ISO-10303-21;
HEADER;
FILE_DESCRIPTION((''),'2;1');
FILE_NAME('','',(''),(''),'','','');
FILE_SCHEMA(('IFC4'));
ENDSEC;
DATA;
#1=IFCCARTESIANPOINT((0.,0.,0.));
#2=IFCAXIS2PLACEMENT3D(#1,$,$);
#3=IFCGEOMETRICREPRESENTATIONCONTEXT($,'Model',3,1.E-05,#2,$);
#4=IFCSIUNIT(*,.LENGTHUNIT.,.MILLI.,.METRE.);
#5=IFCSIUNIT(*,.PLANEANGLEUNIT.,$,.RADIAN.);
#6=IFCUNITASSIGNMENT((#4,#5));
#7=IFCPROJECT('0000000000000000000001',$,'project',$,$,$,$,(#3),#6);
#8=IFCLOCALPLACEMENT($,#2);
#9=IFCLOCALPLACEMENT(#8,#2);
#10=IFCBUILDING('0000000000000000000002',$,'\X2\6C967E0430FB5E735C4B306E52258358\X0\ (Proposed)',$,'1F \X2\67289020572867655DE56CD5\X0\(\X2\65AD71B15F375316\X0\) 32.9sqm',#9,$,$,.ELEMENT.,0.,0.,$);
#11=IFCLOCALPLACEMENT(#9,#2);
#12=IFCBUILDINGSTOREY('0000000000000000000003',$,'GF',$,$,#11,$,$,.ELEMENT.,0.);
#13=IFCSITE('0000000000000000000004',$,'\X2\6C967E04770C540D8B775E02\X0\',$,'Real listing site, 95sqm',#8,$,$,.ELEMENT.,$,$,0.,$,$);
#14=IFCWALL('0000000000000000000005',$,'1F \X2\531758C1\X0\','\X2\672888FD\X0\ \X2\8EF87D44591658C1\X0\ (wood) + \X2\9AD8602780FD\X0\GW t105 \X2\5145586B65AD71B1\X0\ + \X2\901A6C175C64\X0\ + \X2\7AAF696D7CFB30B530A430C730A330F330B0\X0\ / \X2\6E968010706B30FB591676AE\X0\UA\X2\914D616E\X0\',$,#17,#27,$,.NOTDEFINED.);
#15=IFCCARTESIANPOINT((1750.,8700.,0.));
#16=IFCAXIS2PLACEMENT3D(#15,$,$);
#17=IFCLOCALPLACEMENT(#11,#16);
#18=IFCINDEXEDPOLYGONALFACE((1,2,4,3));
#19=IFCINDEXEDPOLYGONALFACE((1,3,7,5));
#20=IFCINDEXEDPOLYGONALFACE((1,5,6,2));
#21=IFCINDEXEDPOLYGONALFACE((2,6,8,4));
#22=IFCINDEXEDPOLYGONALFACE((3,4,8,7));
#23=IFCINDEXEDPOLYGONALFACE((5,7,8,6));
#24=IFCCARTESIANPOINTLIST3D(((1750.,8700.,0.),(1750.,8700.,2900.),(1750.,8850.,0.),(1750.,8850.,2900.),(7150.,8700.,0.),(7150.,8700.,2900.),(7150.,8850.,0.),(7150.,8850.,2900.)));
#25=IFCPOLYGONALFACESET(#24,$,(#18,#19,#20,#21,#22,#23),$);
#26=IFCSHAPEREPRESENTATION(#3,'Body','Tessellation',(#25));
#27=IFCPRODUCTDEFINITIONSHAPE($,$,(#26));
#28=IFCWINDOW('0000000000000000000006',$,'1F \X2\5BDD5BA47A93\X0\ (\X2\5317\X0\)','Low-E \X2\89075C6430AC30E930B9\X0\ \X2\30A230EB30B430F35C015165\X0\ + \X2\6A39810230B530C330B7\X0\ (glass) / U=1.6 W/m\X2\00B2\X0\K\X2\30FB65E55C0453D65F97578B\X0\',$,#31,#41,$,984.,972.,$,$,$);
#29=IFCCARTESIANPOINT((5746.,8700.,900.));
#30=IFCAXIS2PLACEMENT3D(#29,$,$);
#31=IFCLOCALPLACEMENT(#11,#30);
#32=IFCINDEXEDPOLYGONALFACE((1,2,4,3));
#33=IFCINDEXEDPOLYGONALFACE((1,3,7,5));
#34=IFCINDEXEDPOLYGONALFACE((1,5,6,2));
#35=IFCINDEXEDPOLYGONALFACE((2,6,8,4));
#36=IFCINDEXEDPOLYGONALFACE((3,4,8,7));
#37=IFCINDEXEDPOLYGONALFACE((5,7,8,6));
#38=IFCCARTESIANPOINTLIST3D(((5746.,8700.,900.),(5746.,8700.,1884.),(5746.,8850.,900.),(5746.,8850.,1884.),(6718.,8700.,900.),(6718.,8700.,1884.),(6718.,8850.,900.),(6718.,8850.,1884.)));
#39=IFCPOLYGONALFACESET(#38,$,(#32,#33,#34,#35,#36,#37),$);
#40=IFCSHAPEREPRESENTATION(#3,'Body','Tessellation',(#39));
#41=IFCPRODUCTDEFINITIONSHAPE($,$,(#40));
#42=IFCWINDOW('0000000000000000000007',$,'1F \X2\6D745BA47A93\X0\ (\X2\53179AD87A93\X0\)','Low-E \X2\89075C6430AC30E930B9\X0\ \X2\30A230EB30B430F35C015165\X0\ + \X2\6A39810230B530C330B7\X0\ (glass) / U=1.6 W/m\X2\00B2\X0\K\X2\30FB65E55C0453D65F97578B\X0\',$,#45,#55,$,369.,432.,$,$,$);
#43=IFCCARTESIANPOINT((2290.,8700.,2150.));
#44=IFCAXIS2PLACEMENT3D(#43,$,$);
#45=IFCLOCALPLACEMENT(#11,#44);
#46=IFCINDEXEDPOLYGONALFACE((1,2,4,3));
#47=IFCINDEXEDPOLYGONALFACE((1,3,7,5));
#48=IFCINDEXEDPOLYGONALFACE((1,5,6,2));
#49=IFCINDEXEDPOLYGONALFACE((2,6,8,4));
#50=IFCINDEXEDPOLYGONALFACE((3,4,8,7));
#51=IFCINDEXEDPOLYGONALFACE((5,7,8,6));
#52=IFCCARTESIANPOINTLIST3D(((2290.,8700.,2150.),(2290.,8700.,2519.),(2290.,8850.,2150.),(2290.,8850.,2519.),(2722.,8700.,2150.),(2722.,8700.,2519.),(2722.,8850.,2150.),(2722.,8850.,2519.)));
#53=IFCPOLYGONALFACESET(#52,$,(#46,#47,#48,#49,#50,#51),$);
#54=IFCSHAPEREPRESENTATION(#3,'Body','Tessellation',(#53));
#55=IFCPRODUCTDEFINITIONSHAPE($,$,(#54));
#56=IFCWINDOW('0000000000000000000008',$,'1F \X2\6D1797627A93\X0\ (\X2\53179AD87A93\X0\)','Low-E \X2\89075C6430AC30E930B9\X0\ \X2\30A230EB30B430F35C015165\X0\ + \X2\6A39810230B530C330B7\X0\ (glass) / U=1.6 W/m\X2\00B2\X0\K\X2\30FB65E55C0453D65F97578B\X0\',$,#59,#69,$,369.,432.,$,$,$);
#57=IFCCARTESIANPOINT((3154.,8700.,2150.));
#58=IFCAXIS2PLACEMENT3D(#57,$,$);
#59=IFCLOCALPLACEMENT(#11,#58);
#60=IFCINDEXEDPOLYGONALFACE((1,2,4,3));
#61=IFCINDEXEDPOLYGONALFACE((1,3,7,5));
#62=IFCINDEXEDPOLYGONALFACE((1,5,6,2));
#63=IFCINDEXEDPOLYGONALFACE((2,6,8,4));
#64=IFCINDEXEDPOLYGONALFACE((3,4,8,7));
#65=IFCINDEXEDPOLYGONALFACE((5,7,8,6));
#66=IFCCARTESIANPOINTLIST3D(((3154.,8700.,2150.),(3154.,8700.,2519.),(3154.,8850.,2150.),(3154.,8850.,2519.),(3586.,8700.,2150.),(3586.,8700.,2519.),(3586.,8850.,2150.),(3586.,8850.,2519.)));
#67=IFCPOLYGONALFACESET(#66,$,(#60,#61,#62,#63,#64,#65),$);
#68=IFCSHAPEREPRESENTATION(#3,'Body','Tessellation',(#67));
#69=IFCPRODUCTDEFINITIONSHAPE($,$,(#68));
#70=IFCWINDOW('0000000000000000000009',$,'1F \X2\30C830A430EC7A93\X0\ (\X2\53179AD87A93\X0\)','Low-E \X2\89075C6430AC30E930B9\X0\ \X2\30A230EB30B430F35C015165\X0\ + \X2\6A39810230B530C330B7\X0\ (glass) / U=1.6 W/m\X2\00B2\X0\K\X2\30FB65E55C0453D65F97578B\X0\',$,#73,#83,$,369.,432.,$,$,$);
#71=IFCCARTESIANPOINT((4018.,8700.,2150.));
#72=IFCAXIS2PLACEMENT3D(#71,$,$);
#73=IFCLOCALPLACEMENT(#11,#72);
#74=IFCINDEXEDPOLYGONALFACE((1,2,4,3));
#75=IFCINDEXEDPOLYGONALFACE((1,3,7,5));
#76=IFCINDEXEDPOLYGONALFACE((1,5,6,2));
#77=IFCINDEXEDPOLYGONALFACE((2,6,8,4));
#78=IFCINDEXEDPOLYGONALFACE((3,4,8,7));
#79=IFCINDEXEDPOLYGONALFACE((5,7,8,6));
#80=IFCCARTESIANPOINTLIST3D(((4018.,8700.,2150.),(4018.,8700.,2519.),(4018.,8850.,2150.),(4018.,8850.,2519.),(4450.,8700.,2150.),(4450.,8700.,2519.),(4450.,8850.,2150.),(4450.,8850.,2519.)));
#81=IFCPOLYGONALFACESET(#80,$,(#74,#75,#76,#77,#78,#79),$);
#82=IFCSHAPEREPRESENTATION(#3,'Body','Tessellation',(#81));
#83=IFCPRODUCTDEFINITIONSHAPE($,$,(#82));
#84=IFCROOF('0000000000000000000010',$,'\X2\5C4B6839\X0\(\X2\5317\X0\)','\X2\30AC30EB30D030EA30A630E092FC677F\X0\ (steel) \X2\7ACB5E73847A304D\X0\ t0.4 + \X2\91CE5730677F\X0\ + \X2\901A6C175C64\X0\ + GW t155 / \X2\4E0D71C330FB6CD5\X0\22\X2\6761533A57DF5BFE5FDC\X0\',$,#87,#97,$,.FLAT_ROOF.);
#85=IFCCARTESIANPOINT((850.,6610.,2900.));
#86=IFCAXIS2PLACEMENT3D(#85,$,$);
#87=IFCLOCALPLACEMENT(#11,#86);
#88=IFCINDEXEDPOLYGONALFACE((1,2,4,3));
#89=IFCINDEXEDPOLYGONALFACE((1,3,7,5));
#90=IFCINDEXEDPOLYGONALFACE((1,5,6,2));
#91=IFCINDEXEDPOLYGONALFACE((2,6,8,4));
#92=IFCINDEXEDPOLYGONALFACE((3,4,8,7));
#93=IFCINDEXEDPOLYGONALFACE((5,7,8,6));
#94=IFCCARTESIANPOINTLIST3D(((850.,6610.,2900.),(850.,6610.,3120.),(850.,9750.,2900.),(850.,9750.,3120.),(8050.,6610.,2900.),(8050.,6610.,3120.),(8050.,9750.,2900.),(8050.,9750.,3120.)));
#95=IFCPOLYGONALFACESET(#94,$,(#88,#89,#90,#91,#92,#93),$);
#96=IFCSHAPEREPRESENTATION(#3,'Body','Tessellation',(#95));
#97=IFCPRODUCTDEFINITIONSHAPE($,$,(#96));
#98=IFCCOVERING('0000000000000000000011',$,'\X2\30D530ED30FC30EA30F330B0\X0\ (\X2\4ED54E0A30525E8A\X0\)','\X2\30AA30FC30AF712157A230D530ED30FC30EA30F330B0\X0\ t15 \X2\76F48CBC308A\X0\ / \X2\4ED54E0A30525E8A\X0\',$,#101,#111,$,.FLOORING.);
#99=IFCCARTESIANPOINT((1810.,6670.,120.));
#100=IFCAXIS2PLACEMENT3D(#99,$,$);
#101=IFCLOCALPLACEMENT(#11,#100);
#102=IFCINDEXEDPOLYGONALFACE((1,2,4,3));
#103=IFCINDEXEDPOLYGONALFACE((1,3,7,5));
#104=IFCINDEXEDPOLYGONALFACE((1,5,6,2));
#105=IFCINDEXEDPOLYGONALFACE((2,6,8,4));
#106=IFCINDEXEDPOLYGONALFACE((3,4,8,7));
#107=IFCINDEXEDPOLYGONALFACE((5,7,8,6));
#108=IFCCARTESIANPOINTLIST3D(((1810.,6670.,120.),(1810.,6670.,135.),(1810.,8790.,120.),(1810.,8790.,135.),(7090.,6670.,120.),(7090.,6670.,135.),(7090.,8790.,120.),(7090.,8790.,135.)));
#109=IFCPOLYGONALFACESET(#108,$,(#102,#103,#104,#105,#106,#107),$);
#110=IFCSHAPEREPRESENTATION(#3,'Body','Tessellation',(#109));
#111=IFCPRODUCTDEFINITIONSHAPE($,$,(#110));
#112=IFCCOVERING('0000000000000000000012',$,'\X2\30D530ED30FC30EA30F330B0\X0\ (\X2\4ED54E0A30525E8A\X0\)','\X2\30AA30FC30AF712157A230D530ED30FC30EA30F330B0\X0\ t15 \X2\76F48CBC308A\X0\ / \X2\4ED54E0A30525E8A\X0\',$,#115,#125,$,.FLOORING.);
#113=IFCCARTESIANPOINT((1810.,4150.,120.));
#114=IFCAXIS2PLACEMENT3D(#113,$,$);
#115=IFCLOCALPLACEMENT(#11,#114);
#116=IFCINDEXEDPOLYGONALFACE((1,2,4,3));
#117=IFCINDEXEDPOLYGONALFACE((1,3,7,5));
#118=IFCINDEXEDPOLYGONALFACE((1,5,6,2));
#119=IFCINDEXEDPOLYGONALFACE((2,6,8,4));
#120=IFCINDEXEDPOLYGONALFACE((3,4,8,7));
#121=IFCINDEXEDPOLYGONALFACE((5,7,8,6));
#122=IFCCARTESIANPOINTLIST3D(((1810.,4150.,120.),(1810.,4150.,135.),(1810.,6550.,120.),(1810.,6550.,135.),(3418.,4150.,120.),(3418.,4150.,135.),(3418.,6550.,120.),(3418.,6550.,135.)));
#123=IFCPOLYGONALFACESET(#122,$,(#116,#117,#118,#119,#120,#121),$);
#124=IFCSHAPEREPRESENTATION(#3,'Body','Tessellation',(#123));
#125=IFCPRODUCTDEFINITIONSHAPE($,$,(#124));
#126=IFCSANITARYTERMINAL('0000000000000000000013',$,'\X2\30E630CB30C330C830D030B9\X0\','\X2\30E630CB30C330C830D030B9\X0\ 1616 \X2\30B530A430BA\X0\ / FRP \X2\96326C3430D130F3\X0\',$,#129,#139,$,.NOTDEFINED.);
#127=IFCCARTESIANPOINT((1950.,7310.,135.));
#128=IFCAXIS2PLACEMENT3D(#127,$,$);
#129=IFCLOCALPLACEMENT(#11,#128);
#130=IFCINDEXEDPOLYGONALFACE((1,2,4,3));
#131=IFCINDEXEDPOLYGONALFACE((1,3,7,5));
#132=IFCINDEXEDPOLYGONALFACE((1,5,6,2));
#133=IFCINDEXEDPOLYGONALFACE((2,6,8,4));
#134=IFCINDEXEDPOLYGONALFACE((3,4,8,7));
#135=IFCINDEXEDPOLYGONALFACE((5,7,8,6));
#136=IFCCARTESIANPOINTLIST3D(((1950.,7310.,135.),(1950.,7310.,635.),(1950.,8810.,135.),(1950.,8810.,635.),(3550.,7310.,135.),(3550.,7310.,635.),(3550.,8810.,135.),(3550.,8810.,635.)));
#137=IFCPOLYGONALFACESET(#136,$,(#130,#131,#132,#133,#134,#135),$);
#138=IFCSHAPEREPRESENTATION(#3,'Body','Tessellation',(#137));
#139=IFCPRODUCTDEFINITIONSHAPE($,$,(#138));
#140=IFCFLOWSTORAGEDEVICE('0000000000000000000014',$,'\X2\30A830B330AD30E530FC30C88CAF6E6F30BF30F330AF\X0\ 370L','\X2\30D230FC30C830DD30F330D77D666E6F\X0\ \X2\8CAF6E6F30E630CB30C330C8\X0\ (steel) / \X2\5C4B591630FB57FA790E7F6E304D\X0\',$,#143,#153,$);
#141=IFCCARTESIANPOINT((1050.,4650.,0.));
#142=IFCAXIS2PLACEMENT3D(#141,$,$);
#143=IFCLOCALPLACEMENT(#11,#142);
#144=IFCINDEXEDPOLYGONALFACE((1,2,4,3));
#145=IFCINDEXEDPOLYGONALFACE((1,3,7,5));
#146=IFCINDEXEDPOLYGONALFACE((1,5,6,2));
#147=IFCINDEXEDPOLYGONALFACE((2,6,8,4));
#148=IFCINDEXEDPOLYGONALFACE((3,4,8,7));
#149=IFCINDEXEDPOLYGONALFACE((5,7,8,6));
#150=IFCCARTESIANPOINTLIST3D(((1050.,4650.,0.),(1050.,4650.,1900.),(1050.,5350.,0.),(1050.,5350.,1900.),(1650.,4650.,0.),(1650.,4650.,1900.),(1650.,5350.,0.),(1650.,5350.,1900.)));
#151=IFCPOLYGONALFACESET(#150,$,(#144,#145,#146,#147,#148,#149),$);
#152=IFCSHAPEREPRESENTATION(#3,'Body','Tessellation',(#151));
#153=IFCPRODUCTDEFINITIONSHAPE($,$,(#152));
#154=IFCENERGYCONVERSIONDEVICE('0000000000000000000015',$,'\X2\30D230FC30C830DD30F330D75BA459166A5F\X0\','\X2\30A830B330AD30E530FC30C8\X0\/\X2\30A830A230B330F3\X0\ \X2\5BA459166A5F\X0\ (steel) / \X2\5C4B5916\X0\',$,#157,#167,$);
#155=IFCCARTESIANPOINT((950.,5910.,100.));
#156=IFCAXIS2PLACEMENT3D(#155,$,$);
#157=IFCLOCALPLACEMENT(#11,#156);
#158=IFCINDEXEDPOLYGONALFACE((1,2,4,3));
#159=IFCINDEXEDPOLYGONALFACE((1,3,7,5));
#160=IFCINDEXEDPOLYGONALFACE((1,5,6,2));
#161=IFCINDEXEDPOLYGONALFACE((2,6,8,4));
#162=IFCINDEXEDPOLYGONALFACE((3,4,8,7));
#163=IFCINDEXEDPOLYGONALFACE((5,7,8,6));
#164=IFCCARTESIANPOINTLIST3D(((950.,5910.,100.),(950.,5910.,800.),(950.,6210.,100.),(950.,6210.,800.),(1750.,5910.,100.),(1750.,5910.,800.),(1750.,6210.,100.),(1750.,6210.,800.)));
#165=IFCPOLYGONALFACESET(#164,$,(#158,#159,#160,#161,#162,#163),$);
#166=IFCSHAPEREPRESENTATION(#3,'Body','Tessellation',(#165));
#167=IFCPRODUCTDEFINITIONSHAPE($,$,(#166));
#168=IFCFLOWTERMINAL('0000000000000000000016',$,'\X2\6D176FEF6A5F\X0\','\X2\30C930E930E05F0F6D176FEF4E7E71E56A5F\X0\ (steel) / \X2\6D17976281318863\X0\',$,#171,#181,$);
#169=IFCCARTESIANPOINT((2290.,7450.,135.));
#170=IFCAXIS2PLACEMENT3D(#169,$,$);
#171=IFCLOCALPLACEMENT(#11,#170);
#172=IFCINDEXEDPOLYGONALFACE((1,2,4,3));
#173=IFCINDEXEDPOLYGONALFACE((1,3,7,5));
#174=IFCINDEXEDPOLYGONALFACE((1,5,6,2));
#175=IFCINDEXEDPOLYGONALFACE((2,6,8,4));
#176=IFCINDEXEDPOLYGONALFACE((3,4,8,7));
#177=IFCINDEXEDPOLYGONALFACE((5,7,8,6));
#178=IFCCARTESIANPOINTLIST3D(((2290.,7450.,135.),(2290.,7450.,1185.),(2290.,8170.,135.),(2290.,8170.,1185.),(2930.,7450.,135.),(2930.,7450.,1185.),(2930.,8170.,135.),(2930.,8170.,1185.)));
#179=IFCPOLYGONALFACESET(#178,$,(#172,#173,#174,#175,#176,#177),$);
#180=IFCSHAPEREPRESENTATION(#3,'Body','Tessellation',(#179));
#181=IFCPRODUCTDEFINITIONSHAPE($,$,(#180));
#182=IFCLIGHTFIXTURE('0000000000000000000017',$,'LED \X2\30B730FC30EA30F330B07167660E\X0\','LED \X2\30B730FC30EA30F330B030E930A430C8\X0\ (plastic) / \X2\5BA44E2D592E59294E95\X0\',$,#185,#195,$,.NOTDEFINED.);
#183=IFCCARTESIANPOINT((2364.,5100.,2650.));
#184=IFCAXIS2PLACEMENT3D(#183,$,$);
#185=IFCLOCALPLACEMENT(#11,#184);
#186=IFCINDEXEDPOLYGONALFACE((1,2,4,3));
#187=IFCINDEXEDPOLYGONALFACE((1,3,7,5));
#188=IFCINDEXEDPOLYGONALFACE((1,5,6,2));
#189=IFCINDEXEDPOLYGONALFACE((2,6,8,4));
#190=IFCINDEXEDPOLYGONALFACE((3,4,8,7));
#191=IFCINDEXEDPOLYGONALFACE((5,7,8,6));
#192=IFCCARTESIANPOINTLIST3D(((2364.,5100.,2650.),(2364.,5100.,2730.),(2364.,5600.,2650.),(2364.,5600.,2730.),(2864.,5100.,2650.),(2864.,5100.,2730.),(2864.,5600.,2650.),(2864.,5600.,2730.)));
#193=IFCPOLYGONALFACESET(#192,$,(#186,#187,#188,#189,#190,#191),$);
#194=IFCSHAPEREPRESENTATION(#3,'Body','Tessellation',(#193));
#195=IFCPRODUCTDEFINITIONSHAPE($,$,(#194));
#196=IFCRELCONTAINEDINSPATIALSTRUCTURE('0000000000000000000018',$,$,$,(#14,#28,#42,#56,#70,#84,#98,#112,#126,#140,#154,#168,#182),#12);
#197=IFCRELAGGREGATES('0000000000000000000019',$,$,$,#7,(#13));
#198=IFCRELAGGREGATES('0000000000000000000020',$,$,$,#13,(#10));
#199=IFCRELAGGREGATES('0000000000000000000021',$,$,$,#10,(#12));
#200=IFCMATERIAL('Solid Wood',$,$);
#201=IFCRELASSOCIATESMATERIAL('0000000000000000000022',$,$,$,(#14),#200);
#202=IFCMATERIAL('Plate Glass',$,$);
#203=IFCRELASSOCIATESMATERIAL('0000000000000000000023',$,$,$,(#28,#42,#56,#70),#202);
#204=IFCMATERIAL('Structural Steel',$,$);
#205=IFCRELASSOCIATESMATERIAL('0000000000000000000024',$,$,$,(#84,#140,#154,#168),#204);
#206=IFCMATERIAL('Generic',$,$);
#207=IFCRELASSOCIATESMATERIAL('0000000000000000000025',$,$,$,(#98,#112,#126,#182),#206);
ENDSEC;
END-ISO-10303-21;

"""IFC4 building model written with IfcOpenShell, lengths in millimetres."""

from ifc_helpers import new_model, si_unit, frame, frame_2d, origin, place, context, project, spatial, rectangle, extrude, material, element, fill, save


model = new_model("IFC4")

# Units and contexts
model_context = context("Model", 3, precision=1e-05, world=origin())
ifc_project = project(units=[si_unit("LENGTHUNIT", "METRE", prefix="MILLI"), si_unit("PLANEANGLEUNIT", "RADIAN")], contexts=[model_context])

# Site, building, storey
site_placement = place(None, origin())
site = spatial("IfcSite", under=ifc_project, at=site_placement, Name="沖縄県名護市", ObjectType="Real listing site, 95sqm", CompositionType="ELEMENT", RefElevation=0.0)
building_placement = place(site_placement, origin())
building = spatial("IfcBuilding", under=site, at=building_placement, Name="沖縄・平屋の別荘 (Proposed)", ObjectType="1F 木造在来工法(断熱強化) 32.9sqm", CompositionType="ELEMENT", ElevationOfRefHeight=0.0, ElevationOfTerrain=0.0)
storey_placement = place(building_placement, origin())
storey = spatial("IfcBuildingStorey", under=building, at=storey_placement, Name="GF", CompositionType="ELEMENT", Elevation=0.0)

# Shared definitions
ifc_material_1 = material(Name="Solid Wood")

# Wall, openings, windows
wall_1_placement = place(storey_placement, frame((1750.0, 8700.0, 0.0)))
wall_1 = element("IfcWall", 1, at=wall_1_placement, inside=storey, material=ifc_material_1, Name="1F 北壁", Description="木製 軸組外壁 (wood) + 高性能GW t105 充填断熱 + 通気層 + 窯業系サイディング / 準耐火・外皮UA配慮", PredefinedType="NOTDEFINED", context=model_context, shape_type="SweptSolid", body=[
    extrude(rectangle(XDim=5400.0, YDim=150.0, at=frame_2d((2700.0, 75.0))), frame((1750.0, 8700.0, 0.0)), (0.0, 0.0, 1.0), 2900.0),
])
opening_1_placement = place(storey_placement, frame((5746.0, 8700.0, 900.0)))
opening_1 = element("IfcOpeningElement", 2, at=opening_1_placement, cuts=wall_1, PredefinedType="NOTDEFINED", context=model_context, shape_type="SweptSolid", body=[
    extrude(rectangle(XDim=972.0, YDim=150.0, at=frame_2d((486.0, 75.0))), frame((5746.0, 8700.0, 900.0)), (0.0, 0.0, 1.0), 984.0),
])
opening_2_placement = place(storey_placement, frame((2290.0, 8700.0, 2150.0)))
opening_2 = element("IfcOpeningElement", 3, at=opening_2_placement, cuts=wall_1, PredefinedType="NOTDEFINED", context=model_context, shape_type="SweptSolid", body=[
    extrude(rectangle(XDim=432.0, YDim=150.0, at=frame_2d((216.0, 75.0))), frame((2290.0, 8700.0, 2150.0)), (0.0, 0.0, 1.0), 369.0),
])
opening_3_placement = place(storey_placement, frame((3154.0, 8700.0, 2150.0)))
opening_3 = element("IfcOpeningElement", 4, at=opening_3_placement, cuts=wall_1, PredefinedType="NOTDEFINED", context=model_context, shape_type="SweptSolid", body=[
    extrude(rectangle(XDim=432.0, YDim=150.0, at=frame_2d((216.0, 75.0))), frame((3154.0, 8700.0, 2150.0)), (0.0, 0.0, 1.0), 369.0),
])
opening_4_placement = place(storey_placement, frame((4018.0, 8700.0, 2150.0)))
opening_4 = element("IfcOpeningElement", 5, at=opening_4_placement, cuts=wall_1, PredefinedType="NOTDEFINED", context=model_context, shape_type="SweptSolid", body=[
    extrude(rectangle(XDim=432.0, YDim=150.0, at=frame_2d((216.0, 75.0))), frame((4018.0, 8700.0, 2150.0)), (0.0, 0.0, 1.0), 369.0),
])
ifc_material_2 = material(Name="Plate Glass")
window_1_placement = place(storey_placement, frame((5746.0, 8700.0, 900.0)))
window_1 = element("IfcWindow", 6, at=window_1_placement, inside=storey, material=ifc_material_2, Name="1F 寝室窓 (北)", Description="Low-E 複層ガラス アルゴン封入 + 樹脂サッシ (glass) / U=1.6 W/m²K・日射取得型", OverallHeight=984.0, OverallWidth=972.0, context=model_context, shape_type="SweptSolid", body=[
    extrude(rectangle(XDim=972.0, YDim=150.0, at=frame_2d((486.0, 75.0))), frame((5746.0, 8700.0, 900.0)), (0.0, 0.0, 1.0), 984.0),
])
fill(opening_1, window_1)
window_2_placement = place(storey_placement, frame((2290.0, 8700.0, 2150.0)))
window_2 = element("IfcWindow", 7, at=window_2_placement, inside=storey, material=ifc_material_2, Name="1F 浴室窓 (北高窓)", Description="Low-E 複層ガラス アルゴン封入 + 樹脂サッシ (glass) / U=1.6 W/m²K・日射取得型", OverallHeight=369.0, OverallWidth=432.0, context=model_context, shape_type="SweptSolid", body=[
    extrude(rectangle(XDim=432.0, YDim=150.0, at=frame_2d((216.0, 75.0))), frame((2290.0, 8700.0, 2150.0)), (0.0, 0.0, 1.0), 369.0),
])
fill(opening_2, window_2)
window_3_placement = place(storey_placement, frame((3154.0, 8700.0, 2150.0)))
window_3 = element("IfcWindow", 8, at=window_3_placement, inside=storey, material=ifc_material_2, Name="1F 洗面窓 (北高窓)", Description="Low-E 複層ガラス アルゴン封入 + 樹脂サッシ (glass) / U=1.6 W/m²K・日射取得型", OverallHeight=369.0, OverallWidth=432.0, context=model_context, shape_type="SweptSolid", body=[
    extrude(rectangle(XDim=432.0, YDim=150.0, at=frame_2d((216.0, 75.0))), frame((3154.0, 8700.0, 2150.0)), (0.0, 0.0, 1.0), 369.0),
])
fill(opening_3, window_3)
window_4_placement = place(storey_placement, frame((4018.0, 8700.0, 2150.0)))
window_4 = element("IfcWindow", 9, at=window_4_placement, inside=storey, material=ifc_material_2, Name="1F トイレ窓 (北高窓)", Description="Low-E 複層ガラス アルゴン封入 + 樹脂サッシ (glass) / U=1.6 W/m²K・日射取得型", OverallHeight=369.0, OverallWidth=432.0, context=model_context, shape_type="SweptSolid", body=[
    extrude(rectangle(XDim=432.0, YDim=150.0, at=frame_2d((216.0, 75.0))), frame((4018.0, 8700.0, 2150.0)), (0.0, 0.0, 1.0), 369.0),
])
fill(opening_4, window_4)

# Roof
ifc_material_3 = material(Name="Structural Steel")
roof_placement = place(storey_placement, frame((850.0, 6610.0, 2900.0)))
element("IfcRoof", 10, at=roof_placement, inside=storey, material=ifc_material_3, Name="屋根(北)", Description="ガルバリウム鋼板 (steel) 立平葺き t0.4 + 野地板 + 通気層 + GW t155 / 不燃・法22条区域対応", PredefinedType="FLAT_ROOF", context=model_context, shape_type="SweptSolid", body=[
    extrude(rectangle(XDim=7200.0, YDim=3140.0, at=frame_2d((3600.0, 1570.0))), frame((850.0, 6610.0, 2900.0)), (0.0, 0.0, 1.0), 220.0),
])

# Coverings
ifc_material_4 = material(Name="Generic")
covering_1_placement = place(storey_placement, frame((1810.0, 6670.0, 120.0)))
element("IfcCovering", 11, at=covering_1_placement, inside=storey, material=ifc_material_4, Name="フローリング (仕上げ床)", Description="オーク無垢フローリング t15 直貼り / 仕上げ床", PredefinedType="FLOORING", context=model_context, shape_type="SweptSolid", body=[
    extrude(rectangle(XDim=5280.0, YDim=2120.0, at=frame_2d((2640.0, 1060.0))), frame((1810.0, 6670.0, 120.0)), (0.0, 0.0, 1.0), 15.0),
])
covering_2_placement = place(storey_placement, frame((1810.0, 4150.0, 120.0)))
element("IfcCovering", 12, at=covering_2_placement, inside=storey, material=ifc_material_4, Name="フローリング (仕上げ床)", Description="オーク無垢フローリング t15 直貼り / 仕上げ床", PredefinedType="FLOORING", context=model_context, shape_type="SweptSolid", body=[
    extrude(rectangle(XDim=1608.0, YDim=2400.0, at=frame_2d((804.0, 1200.0))), frame((1810.0, 4150.0, 120.0)), (0.0, 0.0, 1.0), 15.0),
])

# Sanitary terminal
sanitary_terminal_placement = place(storey_placement, frame((1950.0, 7310.0, 135.0)))
element("IfcSanitaryTerminal", 13, at=sanitary_terminal_placement, inside=storey, material=ifc_material_4, Name="ユニットバス", Description="ユニットバス 1616 サイズ / FRP 防水パン", PredefinedType="NOTDEFINED", context=model_context, shape_type="SweptSolid", body=[
    extrude(rectangle(XDim=1600.0, YDim=1500.0, at=frame_2d((800.0, 750.0))), frame((1950.0, 7310.0, 135.0)), (0.0, 0.0, 1.0), 500.0),
])

# Flow storage device
flow_storage_device_placement = place(storey_placement, frame((1050.0, 4650.0, 0.0)))
element("IfcFlowStorageDevice", 14, at=flow_storage_device_placement, inside=storey, material=ifc_material_3, Name="エコキュート貯湯タンク 370L", Description="ヒートポンプ給湯 貯湯ユニット (steel) / 屋外・基礎置き", context=model_context, shape_type="SweptSolid", body=[
    extrude(rectangle(XDim=600.0, YDim=700.0, at=frame_2d((300.0, 350.0))), frame((1050.0, 4650.0, 0.0)), (0.0, 0.0, 1.0), 1900.0),
])

# Energy conversion device
energy_conversion_device_placement = place(storey_placement, frame((950.0, 5910.0, 100.0)))
element("IfcEnergyConversionDevice", 15, at=energy_conversion_device_placement, inside=storey, material=ifc_material_3, Name="ヒートポンプ室外機", Description="エコキュート/エアコン 室外機 (steel) / 屋外", context=model_context, shape_type="SweptSolid", body=[
    extrude(rectangle(XDim=800.0, YDim=300.0, at=frame_2d((400.0, 150.0))), frame((950.0, 5910.0, 100.0)), (0.0, 0.0, 1.0), 700.0),
])

# Flow terminal
flow_terminal_placement = place(storey_placement, frame((2290.0, 7450.0, 135.0)))
element("IfcFlowTerminal", 16, at=flow_terminal_placement, inside=storey, material=ifc_material_3, Name="洗濯機", Description="ドラム式洗濯乾燥機 (steel) / 洗面脱衣", context=model_context, shape_type="SweptSolid", body=[
    extrude(rectangle(XDim=640.0, YDim=720.0, at=frame_2d((320.0, 360.0))), frame((2290.0, 7450.0, 135.0)), (0.0, 0.0, 1.0), 1050.0),
])

# Light fixture
light_fixture_placement = place(storey_placement, frame((2364.0, 5100.0, 2650.0)))
element("IfcLightFixture", 17, at=light_fixture_placement, inside=storey, material=ifc_material_4, Name="LED シーリング照明", Description="LED シーリングライト (plastic) / 室中央天井", PredefinedType="NOTDEFINED", context=model_context, shape_type="SweptSolid", body=[
    extrude(rectangle(XDim=500.0, YDim=500.0, at=frame_2d((250.0, 250.0))), frame((2364.0, 5100.0, 2650.0)), (0.0, 0.0, 1.0), 80.0),
])

save(model, "model.ifc")
